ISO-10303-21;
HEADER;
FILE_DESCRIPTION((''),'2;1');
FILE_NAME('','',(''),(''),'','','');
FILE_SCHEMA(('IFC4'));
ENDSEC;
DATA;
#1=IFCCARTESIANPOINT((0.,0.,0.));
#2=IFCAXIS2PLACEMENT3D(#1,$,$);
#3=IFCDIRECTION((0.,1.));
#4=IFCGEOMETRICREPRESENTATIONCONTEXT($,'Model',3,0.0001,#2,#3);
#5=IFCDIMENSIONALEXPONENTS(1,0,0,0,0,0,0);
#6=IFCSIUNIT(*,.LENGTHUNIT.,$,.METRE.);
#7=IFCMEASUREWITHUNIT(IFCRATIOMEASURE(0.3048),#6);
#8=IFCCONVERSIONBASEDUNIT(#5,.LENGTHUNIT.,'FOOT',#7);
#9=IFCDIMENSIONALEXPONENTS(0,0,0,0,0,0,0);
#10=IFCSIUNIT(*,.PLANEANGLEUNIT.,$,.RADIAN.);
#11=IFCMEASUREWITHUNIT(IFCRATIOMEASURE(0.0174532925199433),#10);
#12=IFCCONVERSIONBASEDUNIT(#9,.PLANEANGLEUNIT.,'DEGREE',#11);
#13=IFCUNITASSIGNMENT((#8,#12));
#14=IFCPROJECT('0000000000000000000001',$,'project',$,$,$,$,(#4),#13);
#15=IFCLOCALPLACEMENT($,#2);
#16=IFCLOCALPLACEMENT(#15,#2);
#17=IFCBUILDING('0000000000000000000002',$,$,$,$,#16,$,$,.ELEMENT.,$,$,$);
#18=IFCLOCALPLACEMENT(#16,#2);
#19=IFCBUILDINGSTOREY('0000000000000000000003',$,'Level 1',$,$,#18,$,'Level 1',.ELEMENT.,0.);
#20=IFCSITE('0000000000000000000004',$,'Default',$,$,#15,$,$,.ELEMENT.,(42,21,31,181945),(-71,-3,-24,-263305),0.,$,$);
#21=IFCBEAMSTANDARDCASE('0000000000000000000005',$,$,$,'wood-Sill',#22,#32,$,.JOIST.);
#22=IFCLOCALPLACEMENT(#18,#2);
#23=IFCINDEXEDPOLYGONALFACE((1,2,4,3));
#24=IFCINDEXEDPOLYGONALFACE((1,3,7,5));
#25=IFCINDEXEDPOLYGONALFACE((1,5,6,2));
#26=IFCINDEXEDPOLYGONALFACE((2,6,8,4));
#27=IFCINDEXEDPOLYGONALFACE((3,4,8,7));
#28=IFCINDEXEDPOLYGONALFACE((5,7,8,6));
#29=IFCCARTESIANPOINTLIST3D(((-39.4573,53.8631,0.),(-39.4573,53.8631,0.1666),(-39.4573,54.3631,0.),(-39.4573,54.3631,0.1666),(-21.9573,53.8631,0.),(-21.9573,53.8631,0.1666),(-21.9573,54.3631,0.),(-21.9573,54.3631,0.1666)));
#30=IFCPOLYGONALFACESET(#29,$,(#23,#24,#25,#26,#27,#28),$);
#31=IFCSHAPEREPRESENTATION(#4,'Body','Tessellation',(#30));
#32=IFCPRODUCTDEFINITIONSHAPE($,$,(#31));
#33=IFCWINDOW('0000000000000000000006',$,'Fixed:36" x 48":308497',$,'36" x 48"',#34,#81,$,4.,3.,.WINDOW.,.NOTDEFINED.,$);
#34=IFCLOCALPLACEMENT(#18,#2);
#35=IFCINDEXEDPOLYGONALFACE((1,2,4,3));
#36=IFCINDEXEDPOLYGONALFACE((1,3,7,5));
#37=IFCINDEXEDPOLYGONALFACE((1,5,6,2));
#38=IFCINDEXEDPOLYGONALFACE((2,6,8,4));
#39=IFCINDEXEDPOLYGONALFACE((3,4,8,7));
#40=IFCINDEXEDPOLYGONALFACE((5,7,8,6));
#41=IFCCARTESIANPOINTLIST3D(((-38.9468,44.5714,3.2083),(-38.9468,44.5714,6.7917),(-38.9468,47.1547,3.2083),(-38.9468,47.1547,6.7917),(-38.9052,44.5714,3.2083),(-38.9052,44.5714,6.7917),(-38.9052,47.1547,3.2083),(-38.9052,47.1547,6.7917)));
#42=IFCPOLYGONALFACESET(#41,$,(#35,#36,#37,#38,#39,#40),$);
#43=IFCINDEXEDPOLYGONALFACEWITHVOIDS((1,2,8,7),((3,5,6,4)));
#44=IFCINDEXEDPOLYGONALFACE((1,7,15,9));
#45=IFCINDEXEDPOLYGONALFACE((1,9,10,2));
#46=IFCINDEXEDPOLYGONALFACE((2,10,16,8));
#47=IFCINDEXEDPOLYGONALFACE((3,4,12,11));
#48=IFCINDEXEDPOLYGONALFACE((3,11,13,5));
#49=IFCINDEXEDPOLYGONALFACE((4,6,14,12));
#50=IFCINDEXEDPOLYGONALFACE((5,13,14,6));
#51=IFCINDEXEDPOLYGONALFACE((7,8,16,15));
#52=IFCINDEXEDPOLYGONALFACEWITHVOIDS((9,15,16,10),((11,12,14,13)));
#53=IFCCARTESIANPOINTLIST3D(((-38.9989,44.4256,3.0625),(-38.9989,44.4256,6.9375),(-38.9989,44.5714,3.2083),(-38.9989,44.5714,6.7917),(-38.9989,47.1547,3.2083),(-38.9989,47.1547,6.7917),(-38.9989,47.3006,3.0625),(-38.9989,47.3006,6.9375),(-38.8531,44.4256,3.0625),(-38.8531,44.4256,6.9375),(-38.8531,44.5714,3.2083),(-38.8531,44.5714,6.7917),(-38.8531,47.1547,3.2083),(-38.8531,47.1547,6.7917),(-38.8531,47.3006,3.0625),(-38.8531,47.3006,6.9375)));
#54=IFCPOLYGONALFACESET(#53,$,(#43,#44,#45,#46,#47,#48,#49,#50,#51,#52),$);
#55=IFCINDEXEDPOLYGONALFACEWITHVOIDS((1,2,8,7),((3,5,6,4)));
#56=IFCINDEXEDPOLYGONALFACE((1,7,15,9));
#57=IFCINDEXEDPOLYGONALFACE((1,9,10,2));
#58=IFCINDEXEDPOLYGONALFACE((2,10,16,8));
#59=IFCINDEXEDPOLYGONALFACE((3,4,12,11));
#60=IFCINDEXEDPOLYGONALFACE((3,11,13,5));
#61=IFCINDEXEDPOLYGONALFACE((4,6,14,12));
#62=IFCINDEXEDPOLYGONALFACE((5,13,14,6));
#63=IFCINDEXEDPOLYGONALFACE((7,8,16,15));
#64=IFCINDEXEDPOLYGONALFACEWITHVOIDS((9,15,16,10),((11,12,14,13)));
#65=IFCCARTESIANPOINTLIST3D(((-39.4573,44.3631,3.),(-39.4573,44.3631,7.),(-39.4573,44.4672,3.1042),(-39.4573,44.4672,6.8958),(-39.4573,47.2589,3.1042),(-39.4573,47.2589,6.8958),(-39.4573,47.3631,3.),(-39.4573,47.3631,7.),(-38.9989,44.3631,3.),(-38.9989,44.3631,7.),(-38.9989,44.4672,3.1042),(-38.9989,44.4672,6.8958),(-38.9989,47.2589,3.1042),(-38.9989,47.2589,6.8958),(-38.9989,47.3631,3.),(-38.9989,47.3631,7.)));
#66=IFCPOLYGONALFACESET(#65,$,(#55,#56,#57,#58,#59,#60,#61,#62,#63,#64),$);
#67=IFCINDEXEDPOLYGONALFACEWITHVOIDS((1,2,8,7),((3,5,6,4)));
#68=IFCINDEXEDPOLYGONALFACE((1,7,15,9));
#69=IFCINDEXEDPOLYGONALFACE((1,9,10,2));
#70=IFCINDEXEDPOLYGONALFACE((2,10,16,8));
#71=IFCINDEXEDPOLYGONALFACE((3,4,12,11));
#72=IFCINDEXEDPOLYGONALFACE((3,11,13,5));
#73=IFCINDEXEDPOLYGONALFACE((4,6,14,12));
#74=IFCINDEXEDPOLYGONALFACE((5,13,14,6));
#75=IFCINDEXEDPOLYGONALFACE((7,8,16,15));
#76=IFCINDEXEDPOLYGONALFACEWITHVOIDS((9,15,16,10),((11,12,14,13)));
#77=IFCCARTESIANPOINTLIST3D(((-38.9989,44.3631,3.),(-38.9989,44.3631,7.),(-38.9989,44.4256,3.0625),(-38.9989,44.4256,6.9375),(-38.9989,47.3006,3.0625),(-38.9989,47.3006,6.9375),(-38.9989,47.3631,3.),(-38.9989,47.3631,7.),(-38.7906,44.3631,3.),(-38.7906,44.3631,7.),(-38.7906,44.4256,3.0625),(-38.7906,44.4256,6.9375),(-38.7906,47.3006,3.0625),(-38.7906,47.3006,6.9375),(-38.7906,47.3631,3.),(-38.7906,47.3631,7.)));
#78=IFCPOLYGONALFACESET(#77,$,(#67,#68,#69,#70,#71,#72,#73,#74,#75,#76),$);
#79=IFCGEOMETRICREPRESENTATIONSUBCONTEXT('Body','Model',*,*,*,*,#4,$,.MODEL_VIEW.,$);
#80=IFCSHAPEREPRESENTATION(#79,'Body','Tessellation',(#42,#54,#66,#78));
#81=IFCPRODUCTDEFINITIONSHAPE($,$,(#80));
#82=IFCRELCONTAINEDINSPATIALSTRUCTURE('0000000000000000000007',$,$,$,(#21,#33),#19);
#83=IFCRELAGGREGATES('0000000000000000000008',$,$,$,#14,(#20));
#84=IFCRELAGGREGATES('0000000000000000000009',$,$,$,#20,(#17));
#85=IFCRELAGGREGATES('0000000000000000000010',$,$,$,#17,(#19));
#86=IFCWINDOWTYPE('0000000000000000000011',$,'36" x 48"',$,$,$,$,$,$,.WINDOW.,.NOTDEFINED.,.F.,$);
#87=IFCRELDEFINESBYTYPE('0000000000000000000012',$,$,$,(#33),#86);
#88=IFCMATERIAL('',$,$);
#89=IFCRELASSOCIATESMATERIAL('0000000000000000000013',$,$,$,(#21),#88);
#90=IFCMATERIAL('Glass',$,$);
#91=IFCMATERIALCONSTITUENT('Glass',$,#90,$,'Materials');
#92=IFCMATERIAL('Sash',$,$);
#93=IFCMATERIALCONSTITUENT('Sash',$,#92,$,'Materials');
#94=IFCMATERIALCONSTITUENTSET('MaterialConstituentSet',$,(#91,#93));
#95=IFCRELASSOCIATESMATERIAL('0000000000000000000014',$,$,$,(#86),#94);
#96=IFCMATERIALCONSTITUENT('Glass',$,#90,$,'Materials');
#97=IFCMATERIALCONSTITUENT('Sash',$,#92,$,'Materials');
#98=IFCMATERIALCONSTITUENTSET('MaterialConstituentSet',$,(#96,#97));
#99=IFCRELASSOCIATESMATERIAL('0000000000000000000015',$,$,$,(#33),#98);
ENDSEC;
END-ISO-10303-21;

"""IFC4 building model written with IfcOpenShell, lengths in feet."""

from ifc_helpers import new_model, entity, si_unit, converted_unit, direction, frame, frame_2d, origin, origin_with_axes, place, context, subcontext, project, spatial, polyline, rectangle, outline, extrude, source, transform, mapped, material, constituent, constituent_set, type_object, type_shapes, element, save


model = new_model("IFC4")

# Units and contexts
model_context = context("Model", 3, precision=0.0001, world=origin(), true_north=direction((0.0, 1.0)))
body_context = subcontext(model_context, "Body", "Model", "MODEL_VIEW")
ifc_project = project(units=[converted_unit("LENGTHUNIT", "FOOT", entity("IfcRatioMeasure", 0.3048), si_unit("LENGTHUNIT", "METRE"), dimensions=[1, 0, 0, 0, 0, 0, 0]), converted_unit("PLANEANGLEUNIT", "DEGREE", entity("IfcRatioMeasure", 0.0174532925199433), si_unit("PLANEANGLEUNIT", "RADIAN"), dimensions=[0, 0, 0, 0, 0, 0, 0])], contexts=[model_context])

# Site, building, storey
site_placement = place(None, origin())
site = spatial("IfcSite", under=ifc_project, at=site_placement, Name="Default", CompositionType="ELEMENT", RefLatitude=(42, 21, 31, 181945), RefLongitude=(-71, -3, -24, -263305), RefElevation=0.0)
building_placement = place(site_placement, origin())
building = spatial("IfcBuilding", under=site, at=building_placement, CompositionType="ELEMENT")
storey_placement = place(building_placement, origin())
storey = spatial("IfcBuildingStorey", under=building, at=storey_placement, Name="Level 1", LongName="Level 1", CompositionType="ELEMENT", Elevation=0.0)

# Shared definitions
placement_1 = place(storey_placement, frame((-39.1239, 37.9464, 0.0), z_axis=(0.0, 0.0, 1.0), x_axis=(0.0, 1.0, 0.0)))

# Beam
ifc_material_1 = material(Name="")
placement_2 = place(storey_placement, frame((-39.4573, 54.1131, 0.0)))
beam_placement = place(placement_2, frame((0.0, 0.0, 0.0833), z_axis=(1.0, 0.0, 0.0), x_axis=(0.0, 0.0, 1.0)))
element("IfcBeamStandardCase", 1, at=beam_placement, inside=storey, material=ifc_material_1, ObjectType="wood-Sill", PredefinedType="JOIST", context=model_context, shape_type="SweptSolid", body=[
    extrude(rectangle(XDim=0.1667, YDim=0.5), origin_with_axes(), (0.0, 0.0, 1.0), 17.5),
])

# Window
ifc_material_2 = material(Name="Glass")
ifc_constituent_1 = constituent(ifc_material_2, Name="Glass", Category="Materials")
ifc_material_3 = material(Name="Sash")
ifc_constituent_2 = constituent(ifc_material_3, Name="Sash", Category="Materials")
ifc_constituent_set_1 = constituent_set(constituents=[ifc_constituent_1, ifc_constituent_2], Name="MaterialConstituentSet")
ifc_constituent_3 = constituent(ifc_material_2, Name="Glass", Category="Materials")
ifc_constituent_4 = constituent(ifc_material_3, Name="Sash", Category="Materials")
ifc_constituent_set_2 = constituent_set(constituents=[ifc_constituent_3, ifc_constituent_4], Name="MaterialConstituentSet")
window_type = type_object("IfcWindowType", Name="36\" x 48\"", ParameterTakesPrecedence=False, PartitioningType="NOTDEFINED", PredefinedType="WINDOW", material=ifc_constituent_set_2)
shared_shape = source(origin(), body_context, "Body", "SweptSolid", [
    extrude(rectangle(XDim=0.0417, YDim=2.5833, at=frame_2d((0.0, 0.0), x_axis=(1.0, 0.0))), frame((1.5, 0.5312, 0.2083), z_axis=(0.0, 0.0, 1.0), x_axis=(0.0, 1.0, 0.0)), (0.0, 0.0, 1.0), 3.5833),
    extrude(outline(polyline([(-1.4375, -1.9375), (1.4375, -1.9375), (1.4375, 1.9375), (-1.4375, 1.9375), (-1.4375, -1.9375)]), holes=[polyline([(-1.2917, -1.7917), (-1.2917, 1.7917), (1.2917, 1.7917), (1.2917, -1.7917), (-1.2917, -1.7917)])]), frame((1.5, 0.4583, 2.0), z_axis=(0.0, 1.0, 0.0), x_axis=(1.0, 0.0, 0.0)), (0.0, 0.0, 1.0), 0.1458),
    extrude(outline(polyline([(-1.5, -2.0), (1.5, -2.0), (1.5, 2.0), (-1.5, 2.0), (-1.5, -2.0)]), holes=[polyline([(-1.3958, -1.8958), (-1.3958, 1.8958), (1.3958, 1.8958), (1.3958, -1.8958), (-1.3958, -1.8958)])]), frame((1.5, 0.0, 2.0), z_axis=(0.0, 1.0, 0.0), x_axis=(1.0, 0.0, 0.0)), (0.0, 0.0, 1.0), 0.4583),
    extrude(outline(polyline([(-2.0, -1.5), (2.0, -1.5), (2.0, 1.5), (-2.0, 1.5), (-2.0, -1.5)]), holes=[polyline([(-1.9375, -1.4375), (-1.9375, 1.4375), (1.9375, 1.4375), (1.9375, -1.4375), (-1.9375, -1.4375)])]), frame((1.5, 0.4583, 2.0), z_axis=(0.0, 1.0, 0.0), x_axis=(0.0, 0.0, -1.0)), (0.0, 0.0, 1.0), 0.2083),
])
type_shapes(window_type, [shared_shape])
placement_3 = place(placement_1, frame((9.4167, 0.3333, 3.0)))
window_placement = place(placement_3, frame((0.0, 0.0, 0.0), z_axis=(0.0, 0.0, 1.0), x_axis=(-1.0, 0.0, 0.0)))
element("IfcWindow", 2, at=window_placement, inside=storey, type_object=window_type, material=ifc_constituent_set_1, Name="Fixed:36\" x 48\":308497", ObjectType="36\" x 48\"", OverallHeight=4.0, OverallWidth=3.0, PartitioningType="NOTDEFINED", PredefinedType="WINDOW", context=body_context, shape_type="MappedRepresentation", body=[
    mapped(shared_shape, transform((0.0, 0.0, 0.0), scale=1.0)),
])

save(model, "model.ifc")
